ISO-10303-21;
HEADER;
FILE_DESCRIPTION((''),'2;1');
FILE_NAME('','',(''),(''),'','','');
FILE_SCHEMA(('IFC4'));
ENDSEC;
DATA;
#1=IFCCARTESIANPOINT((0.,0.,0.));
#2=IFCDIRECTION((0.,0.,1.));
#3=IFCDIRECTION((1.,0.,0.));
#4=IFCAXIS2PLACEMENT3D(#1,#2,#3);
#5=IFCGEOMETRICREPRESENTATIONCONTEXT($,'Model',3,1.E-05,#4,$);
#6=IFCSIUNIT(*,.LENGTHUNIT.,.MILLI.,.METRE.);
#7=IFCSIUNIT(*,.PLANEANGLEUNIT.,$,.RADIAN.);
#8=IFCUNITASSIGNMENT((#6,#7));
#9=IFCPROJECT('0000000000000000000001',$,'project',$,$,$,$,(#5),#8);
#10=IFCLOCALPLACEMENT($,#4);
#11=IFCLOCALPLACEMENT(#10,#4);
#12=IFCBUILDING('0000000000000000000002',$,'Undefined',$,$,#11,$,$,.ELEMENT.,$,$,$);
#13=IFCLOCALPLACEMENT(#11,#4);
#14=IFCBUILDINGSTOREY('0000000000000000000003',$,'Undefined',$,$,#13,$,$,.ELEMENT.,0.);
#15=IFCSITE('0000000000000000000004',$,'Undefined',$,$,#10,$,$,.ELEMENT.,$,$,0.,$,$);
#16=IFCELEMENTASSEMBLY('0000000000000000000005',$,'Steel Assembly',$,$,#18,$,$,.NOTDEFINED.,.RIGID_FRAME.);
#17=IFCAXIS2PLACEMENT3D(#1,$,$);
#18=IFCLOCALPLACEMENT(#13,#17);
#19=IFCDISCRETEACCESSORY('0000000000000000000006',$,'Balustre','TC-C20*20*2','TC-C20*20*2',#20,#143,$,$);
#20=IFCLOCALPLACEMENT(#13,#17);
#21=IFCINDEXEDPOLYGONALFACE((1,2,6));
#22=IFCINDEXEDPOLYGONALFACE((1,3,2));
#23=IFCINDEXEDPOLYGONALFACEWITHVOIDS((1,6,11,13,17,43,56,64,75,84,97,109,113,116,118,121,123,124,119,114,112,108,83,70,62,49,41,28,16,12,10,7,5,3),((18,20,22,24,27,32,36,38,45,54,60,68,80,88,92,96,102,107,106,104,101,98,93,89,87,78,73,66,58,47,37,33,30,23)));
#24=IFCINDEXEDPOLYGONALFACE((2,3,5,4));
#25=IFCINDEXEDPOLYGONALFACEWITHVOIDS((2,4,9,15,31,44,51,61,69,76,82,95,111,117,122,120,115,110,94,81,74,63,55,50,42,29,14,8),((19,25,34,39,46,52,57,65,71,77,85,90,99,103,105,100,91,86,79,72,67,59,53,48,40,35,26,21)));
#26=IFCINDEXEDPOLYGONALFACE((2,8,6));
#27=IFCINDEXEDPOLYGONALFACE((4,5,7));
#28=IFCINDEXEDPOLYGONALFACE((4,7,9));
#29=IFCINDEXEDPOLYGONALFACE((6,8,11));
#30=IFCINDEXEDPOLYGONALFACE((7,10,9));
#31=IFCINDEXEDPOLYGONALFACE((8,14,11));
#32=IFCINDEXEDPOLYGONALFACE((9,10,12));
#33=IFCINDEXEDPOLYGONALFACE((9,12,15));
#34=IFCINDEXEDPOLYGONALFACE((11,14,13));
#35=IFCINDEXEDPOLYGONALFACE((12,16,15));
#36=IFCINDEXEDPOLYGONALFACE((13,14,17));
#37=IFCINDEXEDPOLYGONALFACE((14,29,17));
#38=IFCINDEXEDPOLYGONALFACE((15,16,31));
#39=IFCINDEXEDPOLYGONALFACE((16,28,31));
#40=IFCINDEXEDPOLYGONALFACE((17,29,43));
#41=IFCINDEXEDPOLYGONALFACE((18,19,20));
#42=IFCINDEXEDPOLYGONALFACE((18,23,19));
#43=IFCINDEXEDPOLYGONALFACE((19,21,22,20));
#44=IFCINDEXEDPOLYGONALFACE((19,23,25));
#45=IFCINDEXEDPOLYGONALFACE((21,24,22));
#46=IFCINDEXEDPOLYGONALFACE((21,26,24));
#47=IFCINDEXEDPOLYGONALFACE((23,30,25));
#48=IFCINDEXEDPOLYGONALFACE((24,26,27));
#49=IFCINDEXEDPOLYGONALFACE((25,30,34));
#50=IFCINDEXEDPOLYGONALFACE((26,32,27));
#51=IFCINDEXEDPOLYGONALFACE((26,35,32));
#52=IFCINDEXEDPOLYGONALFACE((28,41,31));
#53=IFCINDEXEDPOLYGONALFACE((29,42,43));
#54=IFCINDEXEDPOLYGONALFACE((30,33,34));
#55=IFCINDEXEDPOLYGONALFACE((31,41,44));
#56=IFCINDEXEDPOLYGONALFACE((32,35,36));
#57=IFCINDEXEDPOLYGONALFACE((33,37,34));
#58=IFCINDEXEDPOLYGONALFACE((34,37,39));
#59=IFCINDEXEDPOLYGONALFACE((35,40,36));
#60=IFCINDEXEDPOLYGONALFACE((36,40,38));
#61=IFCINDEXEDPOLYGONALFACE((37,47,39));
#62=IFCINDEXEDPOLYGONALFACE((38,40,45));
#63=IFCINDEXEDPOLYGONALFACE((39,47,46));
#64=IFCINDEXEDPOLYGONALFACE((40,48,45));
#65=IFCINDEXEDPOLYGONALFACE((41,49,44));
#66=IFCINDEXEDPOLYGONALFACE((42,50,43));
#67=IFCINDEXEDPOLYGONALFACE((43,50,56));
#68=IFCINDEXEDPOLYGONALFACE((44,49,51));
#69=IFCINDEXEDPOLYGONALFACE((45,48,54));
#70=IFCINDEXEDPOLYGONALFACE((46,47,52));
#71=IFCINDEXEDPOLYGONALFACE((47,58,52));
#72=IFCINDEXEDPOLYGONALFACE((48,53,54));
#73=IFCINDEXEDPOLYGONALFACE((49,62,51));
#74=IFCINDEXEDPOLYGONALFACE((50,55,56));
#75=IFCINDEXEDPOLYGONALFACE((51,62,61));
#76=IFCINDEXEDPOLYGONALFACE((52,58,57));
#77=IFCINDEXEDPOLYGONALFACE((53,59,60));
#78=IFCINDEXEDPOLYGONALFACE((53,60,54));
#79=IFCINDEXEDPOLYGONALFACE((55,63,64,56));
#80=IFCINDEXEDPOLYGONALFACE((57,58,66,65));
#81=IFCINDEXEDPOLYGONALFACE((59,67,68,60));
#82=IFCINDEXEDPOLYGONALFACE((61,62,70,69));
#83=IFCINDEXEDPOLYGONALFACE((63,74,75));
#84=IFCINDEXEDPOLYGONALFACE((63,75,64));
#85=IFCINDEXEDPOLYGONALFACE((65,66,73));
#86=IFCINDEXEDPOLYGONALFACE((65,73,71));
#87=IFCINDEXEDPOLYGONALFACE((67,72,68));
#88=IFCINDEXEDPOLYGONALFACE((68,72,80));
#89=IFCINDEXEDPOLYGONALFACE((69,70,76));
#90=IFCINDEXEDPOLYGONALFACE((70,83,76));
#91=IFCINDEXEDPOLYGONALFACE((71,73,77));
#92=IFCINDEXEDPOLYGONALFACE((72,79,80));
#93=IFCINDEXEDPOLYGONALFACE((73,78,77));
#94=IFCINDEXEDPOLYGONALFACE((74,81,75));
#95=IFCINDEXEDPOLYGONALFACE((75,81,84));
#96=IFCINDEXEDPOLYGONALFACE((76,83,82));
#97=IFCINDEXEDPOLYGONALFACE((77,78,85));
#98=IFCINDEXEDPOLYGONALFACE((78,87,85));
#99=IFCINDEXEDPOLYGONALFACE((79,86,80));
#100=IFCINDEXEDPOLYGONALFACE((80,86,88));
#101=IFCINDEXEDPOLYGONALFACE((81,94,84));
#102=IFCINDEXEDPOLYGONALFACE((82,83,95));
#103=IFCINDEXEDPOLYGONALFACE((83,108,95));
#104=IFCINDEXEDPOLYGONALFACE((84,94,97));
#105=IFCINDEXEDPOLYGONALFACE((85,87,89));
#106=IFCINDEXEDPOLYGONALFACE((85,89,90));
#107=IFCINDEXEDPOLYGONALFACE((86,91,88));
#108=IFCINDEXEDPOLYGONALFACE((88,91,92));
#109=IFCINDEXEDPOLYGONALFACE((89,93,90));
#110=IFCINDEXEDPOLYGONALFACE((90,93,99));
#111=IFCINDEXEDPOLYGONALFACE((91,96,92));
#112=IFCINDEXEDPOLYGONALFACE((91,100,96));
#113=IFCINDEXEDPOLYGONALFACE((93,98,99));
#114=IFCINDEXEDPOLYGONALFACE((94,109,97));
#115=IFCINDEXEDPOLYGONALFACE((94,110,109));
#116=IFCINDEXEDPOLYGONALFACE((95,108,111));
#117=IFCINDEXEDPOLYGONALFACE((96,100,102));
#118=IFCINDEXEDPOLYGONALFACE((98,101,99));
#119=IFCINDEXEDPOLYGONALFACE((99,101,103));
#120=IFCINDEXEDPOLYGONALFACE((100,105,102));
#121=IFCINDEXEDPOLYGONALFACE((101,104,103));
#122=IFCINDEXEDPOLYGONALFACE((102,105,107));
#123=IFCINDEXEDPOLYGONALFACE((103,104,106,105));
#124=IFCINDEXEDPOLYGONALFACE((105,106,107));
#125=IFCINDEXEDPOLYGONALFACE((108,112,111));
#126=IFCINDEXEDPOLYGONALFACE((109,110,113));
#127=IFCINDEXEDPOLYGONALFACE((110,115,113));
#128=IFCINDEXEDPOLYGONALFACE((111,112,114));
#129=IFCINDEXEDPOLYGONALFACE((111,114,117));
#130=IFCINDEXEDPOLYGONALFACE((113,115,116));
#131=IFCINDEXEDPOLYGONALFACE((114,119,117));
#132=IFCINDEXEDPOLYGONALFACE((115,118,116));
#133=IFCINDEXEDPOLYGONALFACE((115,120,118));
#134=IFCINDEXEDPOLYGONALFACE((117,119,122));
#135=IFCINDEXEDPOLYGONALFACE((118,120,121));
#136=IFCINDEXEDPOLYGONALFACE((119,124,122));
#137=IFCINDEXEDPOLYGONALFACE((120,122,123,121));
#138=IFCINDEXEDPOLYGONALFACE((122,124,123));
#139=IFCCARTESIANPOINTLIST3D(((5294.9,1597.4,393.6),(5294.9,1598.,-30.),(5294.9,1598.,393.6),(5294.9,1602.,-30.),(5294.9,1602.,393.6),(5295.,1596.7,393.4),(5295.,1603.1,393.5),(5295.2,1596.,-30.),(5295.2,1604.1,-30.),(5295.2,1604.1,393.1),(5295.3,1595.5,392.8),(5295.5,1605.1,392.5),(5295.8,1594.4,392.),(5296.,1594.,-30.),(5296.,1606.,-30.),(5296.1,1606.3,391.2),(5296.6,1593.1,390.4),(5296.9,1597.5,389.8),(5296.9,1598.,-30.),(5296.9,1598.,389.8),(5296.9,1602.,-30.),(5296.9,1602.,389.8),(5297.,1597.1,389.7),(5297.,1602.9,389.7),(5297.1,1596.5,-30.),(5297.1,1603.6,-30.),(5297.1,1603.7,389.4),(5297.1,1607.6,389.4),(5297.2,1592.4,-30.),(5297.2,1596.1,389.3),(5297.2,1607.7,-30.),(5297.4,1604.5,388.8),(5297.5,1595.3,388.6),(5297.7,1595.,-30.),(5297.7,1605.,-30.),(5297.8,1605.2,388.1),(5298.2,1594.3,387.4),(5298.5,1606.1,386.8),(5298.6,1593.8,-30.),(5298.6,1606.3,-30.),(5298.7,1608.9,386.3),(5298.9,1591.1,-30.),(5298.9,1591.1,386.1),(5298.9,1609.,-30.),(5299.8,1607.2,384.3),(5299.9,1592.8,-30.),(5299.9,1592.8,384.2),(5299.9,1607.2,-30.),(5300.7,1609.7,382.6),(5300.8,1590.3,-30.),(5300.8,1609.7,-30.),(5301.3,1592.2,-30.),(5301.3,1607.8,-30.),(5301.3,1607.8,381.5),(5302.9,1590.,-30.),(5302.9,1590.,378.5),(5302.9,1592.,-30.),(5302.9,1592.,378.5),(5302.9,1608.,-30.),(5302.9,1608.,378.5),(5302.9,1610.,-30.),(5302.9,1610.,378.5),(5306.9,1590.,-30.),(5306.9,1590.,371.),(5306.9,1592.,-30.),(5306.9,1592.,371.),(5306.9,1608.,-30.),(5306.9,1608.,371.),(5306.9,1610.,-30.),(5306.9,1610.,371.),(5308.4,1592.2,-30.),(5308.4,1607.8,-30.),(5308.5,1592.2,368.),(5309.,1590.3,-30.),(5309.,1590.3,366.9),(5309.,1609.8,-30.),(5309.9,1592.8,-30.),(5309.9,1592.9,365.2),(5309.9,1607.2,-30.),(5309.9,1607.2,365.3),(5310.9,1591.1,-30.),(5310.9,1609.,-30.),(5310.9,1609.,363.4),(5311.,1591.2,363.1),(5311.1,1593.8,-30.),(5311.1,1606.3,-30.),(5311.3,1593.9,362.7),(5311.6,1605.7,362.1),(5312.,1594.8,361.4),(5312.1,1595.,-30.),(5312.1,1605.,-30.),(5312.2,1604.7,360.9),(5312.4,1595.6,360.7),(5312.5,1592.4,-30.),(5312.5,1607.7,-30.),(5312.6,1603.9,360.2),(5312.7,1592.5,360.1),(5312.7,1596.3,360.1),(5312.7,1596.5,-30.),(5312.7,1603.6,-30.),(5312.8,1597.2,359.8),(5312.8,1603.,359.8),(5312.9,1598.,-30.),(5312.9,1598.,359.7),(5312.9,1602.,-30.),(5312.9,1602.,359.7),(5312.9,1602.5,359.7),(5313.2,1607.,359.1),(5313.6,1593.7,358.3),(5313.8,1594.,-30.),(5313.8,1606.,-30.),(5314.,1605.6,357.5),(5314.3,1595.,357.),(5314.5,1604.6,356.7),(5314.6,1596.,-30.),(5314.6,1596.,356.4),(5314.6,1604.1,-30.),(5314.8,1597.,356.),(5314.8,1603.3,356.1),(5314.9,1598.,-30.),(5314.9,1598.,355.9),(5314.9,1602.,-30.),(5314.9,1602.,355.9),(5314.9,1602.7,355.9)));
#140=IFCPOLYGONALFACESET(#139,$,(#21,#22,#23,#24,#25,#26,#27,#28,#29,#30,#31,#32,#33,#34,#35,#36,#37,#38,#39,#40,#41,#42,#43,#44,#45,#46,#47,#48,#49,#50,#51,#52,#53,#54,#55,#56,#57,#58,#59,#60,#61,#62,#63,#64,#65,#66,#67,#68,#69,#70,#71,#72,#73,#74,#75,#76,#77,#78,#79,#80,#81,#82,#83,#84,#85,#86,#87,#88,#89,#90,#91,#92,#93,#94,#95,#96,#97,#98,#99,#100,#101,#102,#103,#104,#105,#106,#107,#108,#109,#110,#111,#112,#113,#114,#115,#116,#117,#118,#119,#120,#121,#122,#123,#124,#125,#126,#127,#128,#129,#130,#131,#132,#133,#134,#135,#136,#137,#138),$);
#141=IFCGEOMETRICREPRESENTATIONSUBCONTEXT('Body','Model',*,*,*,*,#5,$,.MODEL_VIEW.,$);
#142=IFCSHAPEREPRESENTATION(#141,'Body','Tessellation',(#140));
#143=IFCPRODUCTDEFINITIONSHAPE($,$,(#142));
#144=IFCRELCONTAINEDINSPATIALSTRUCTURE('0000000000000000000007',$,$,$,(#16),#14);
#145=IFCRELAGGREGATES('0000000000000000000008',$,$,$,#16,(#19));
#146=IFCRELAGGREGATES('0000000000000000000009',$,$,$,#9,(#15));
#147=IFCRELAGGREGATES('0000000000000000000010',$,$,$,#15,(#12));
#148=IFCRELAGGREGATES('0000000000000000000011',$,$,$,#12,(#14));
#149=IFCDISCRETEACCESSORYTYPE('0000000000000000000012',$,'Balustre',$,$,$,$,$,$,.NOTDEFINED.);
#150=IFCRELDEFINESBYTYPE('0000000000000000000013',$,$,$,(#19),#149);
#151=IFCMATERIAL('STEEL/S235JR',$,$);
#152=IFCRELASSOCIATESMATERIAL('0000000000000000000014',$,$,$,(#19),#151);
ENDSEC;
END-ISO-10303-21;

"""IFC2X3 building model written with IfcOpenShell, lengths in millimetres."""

from ifc_helpers import new_model, si_unit, frame, origin_with_axes, origin_2d_with_axis, place, context, subcontext, project, spatial, hollow_rectangle, extrude, clip, halfspace, material, type_object, element, aggregate, save


model = new_model("IFC2X3")

# Units and contexts
model_context = context("Model", 3, precision=1e-05, world=origin_with_axes())
body_context = subcontext(model_context, "Body", "Model", "MODEL_VIEW")
ifc_project = project(units=[si_unit("LENGTHUNIT", "METRE", prefix="MILLI"), si_unit("PLANEANGLEUNIT", "RADIAN")], contexts=[model_context])

# Site, building, storey
site_placement = place(None, origin_with_axes())
site = spatial("IfcSite", under=ifc_project, at=site_placement, Name="Undefined", CompositionType="ELEMENT", RefElevation=0.0)
building_placement = place(site_placement, origin_with_axes())
building = spatial("IfcBuilding", under=site, at=building_placement, Name="Undefined", CompositionType="ELEMENT")
storey_placement = place(building_placement, origin_with_axes())
storey = spatial("IfcBuildingStorey", under=building, at=storey_placement, Name="Undefined", CompositionType="ELEMENT", Elevation=0.0)

# Shared definitions
ifc_material = material(Name="STEEL/S235JR")

# Element assembly, discrete accessory
assembly_1_placement = place(storey_placement, origin_with_axes())
assembly_1 = element("IfcElementAssembly", 1, at=assembly_1_placement, inside=storey, Name="Steel Assembly", AssemblyPlace="NOTDEFINED", PredefinedType="RIGID_FRAME")
discrete_accessory_type_1 = type_object("IfcDiscreteAccessoryType", Name="Balustre")
discrete_accessory_1_placement = place(assembly_1_placement, frame((5304.9, 1600.0, -30.0), z_axis=(0.0, 0.0, 1.0), x_axis=(1.0, 0.0, 0.0)))
discrete_accessory_1 = element("IfcDiscreteAccessory", 2, at=discrete_accessory_1_placement, type_object=discrete_accessory_type_1, material=ifc_material, Name="Balustre", Description="TC-C20*20*2", ObjectType="TC-C20*20*2", context=body_context, shape_type="Clipping", body=[
    clip(extrude(hollow_rectangle(XDim=20.0, YDim=20.0, WallThickness=2.0, InnerFilletRadius=6.0, OuterFilletRadius=8.0, at=origin_2d_with_axis()), frame((0.0, 0.0, 423.8), z_axis=(0.0, 0.0, -1.0), x_axis=(-1.0, -0.000011, 0.0)), (0.0, 0.0, 1.0), 423.8), halfspace(frame((63.3, 0.0, 285.4), z_axis=(-0.883506, -0.000005, -0.46842), x_axis=(-0.000005, 1.0, 0.0)), True)),
])

aggregate(assembly_1, [discrete_accessory_1])

save(model, "model.ifc")
